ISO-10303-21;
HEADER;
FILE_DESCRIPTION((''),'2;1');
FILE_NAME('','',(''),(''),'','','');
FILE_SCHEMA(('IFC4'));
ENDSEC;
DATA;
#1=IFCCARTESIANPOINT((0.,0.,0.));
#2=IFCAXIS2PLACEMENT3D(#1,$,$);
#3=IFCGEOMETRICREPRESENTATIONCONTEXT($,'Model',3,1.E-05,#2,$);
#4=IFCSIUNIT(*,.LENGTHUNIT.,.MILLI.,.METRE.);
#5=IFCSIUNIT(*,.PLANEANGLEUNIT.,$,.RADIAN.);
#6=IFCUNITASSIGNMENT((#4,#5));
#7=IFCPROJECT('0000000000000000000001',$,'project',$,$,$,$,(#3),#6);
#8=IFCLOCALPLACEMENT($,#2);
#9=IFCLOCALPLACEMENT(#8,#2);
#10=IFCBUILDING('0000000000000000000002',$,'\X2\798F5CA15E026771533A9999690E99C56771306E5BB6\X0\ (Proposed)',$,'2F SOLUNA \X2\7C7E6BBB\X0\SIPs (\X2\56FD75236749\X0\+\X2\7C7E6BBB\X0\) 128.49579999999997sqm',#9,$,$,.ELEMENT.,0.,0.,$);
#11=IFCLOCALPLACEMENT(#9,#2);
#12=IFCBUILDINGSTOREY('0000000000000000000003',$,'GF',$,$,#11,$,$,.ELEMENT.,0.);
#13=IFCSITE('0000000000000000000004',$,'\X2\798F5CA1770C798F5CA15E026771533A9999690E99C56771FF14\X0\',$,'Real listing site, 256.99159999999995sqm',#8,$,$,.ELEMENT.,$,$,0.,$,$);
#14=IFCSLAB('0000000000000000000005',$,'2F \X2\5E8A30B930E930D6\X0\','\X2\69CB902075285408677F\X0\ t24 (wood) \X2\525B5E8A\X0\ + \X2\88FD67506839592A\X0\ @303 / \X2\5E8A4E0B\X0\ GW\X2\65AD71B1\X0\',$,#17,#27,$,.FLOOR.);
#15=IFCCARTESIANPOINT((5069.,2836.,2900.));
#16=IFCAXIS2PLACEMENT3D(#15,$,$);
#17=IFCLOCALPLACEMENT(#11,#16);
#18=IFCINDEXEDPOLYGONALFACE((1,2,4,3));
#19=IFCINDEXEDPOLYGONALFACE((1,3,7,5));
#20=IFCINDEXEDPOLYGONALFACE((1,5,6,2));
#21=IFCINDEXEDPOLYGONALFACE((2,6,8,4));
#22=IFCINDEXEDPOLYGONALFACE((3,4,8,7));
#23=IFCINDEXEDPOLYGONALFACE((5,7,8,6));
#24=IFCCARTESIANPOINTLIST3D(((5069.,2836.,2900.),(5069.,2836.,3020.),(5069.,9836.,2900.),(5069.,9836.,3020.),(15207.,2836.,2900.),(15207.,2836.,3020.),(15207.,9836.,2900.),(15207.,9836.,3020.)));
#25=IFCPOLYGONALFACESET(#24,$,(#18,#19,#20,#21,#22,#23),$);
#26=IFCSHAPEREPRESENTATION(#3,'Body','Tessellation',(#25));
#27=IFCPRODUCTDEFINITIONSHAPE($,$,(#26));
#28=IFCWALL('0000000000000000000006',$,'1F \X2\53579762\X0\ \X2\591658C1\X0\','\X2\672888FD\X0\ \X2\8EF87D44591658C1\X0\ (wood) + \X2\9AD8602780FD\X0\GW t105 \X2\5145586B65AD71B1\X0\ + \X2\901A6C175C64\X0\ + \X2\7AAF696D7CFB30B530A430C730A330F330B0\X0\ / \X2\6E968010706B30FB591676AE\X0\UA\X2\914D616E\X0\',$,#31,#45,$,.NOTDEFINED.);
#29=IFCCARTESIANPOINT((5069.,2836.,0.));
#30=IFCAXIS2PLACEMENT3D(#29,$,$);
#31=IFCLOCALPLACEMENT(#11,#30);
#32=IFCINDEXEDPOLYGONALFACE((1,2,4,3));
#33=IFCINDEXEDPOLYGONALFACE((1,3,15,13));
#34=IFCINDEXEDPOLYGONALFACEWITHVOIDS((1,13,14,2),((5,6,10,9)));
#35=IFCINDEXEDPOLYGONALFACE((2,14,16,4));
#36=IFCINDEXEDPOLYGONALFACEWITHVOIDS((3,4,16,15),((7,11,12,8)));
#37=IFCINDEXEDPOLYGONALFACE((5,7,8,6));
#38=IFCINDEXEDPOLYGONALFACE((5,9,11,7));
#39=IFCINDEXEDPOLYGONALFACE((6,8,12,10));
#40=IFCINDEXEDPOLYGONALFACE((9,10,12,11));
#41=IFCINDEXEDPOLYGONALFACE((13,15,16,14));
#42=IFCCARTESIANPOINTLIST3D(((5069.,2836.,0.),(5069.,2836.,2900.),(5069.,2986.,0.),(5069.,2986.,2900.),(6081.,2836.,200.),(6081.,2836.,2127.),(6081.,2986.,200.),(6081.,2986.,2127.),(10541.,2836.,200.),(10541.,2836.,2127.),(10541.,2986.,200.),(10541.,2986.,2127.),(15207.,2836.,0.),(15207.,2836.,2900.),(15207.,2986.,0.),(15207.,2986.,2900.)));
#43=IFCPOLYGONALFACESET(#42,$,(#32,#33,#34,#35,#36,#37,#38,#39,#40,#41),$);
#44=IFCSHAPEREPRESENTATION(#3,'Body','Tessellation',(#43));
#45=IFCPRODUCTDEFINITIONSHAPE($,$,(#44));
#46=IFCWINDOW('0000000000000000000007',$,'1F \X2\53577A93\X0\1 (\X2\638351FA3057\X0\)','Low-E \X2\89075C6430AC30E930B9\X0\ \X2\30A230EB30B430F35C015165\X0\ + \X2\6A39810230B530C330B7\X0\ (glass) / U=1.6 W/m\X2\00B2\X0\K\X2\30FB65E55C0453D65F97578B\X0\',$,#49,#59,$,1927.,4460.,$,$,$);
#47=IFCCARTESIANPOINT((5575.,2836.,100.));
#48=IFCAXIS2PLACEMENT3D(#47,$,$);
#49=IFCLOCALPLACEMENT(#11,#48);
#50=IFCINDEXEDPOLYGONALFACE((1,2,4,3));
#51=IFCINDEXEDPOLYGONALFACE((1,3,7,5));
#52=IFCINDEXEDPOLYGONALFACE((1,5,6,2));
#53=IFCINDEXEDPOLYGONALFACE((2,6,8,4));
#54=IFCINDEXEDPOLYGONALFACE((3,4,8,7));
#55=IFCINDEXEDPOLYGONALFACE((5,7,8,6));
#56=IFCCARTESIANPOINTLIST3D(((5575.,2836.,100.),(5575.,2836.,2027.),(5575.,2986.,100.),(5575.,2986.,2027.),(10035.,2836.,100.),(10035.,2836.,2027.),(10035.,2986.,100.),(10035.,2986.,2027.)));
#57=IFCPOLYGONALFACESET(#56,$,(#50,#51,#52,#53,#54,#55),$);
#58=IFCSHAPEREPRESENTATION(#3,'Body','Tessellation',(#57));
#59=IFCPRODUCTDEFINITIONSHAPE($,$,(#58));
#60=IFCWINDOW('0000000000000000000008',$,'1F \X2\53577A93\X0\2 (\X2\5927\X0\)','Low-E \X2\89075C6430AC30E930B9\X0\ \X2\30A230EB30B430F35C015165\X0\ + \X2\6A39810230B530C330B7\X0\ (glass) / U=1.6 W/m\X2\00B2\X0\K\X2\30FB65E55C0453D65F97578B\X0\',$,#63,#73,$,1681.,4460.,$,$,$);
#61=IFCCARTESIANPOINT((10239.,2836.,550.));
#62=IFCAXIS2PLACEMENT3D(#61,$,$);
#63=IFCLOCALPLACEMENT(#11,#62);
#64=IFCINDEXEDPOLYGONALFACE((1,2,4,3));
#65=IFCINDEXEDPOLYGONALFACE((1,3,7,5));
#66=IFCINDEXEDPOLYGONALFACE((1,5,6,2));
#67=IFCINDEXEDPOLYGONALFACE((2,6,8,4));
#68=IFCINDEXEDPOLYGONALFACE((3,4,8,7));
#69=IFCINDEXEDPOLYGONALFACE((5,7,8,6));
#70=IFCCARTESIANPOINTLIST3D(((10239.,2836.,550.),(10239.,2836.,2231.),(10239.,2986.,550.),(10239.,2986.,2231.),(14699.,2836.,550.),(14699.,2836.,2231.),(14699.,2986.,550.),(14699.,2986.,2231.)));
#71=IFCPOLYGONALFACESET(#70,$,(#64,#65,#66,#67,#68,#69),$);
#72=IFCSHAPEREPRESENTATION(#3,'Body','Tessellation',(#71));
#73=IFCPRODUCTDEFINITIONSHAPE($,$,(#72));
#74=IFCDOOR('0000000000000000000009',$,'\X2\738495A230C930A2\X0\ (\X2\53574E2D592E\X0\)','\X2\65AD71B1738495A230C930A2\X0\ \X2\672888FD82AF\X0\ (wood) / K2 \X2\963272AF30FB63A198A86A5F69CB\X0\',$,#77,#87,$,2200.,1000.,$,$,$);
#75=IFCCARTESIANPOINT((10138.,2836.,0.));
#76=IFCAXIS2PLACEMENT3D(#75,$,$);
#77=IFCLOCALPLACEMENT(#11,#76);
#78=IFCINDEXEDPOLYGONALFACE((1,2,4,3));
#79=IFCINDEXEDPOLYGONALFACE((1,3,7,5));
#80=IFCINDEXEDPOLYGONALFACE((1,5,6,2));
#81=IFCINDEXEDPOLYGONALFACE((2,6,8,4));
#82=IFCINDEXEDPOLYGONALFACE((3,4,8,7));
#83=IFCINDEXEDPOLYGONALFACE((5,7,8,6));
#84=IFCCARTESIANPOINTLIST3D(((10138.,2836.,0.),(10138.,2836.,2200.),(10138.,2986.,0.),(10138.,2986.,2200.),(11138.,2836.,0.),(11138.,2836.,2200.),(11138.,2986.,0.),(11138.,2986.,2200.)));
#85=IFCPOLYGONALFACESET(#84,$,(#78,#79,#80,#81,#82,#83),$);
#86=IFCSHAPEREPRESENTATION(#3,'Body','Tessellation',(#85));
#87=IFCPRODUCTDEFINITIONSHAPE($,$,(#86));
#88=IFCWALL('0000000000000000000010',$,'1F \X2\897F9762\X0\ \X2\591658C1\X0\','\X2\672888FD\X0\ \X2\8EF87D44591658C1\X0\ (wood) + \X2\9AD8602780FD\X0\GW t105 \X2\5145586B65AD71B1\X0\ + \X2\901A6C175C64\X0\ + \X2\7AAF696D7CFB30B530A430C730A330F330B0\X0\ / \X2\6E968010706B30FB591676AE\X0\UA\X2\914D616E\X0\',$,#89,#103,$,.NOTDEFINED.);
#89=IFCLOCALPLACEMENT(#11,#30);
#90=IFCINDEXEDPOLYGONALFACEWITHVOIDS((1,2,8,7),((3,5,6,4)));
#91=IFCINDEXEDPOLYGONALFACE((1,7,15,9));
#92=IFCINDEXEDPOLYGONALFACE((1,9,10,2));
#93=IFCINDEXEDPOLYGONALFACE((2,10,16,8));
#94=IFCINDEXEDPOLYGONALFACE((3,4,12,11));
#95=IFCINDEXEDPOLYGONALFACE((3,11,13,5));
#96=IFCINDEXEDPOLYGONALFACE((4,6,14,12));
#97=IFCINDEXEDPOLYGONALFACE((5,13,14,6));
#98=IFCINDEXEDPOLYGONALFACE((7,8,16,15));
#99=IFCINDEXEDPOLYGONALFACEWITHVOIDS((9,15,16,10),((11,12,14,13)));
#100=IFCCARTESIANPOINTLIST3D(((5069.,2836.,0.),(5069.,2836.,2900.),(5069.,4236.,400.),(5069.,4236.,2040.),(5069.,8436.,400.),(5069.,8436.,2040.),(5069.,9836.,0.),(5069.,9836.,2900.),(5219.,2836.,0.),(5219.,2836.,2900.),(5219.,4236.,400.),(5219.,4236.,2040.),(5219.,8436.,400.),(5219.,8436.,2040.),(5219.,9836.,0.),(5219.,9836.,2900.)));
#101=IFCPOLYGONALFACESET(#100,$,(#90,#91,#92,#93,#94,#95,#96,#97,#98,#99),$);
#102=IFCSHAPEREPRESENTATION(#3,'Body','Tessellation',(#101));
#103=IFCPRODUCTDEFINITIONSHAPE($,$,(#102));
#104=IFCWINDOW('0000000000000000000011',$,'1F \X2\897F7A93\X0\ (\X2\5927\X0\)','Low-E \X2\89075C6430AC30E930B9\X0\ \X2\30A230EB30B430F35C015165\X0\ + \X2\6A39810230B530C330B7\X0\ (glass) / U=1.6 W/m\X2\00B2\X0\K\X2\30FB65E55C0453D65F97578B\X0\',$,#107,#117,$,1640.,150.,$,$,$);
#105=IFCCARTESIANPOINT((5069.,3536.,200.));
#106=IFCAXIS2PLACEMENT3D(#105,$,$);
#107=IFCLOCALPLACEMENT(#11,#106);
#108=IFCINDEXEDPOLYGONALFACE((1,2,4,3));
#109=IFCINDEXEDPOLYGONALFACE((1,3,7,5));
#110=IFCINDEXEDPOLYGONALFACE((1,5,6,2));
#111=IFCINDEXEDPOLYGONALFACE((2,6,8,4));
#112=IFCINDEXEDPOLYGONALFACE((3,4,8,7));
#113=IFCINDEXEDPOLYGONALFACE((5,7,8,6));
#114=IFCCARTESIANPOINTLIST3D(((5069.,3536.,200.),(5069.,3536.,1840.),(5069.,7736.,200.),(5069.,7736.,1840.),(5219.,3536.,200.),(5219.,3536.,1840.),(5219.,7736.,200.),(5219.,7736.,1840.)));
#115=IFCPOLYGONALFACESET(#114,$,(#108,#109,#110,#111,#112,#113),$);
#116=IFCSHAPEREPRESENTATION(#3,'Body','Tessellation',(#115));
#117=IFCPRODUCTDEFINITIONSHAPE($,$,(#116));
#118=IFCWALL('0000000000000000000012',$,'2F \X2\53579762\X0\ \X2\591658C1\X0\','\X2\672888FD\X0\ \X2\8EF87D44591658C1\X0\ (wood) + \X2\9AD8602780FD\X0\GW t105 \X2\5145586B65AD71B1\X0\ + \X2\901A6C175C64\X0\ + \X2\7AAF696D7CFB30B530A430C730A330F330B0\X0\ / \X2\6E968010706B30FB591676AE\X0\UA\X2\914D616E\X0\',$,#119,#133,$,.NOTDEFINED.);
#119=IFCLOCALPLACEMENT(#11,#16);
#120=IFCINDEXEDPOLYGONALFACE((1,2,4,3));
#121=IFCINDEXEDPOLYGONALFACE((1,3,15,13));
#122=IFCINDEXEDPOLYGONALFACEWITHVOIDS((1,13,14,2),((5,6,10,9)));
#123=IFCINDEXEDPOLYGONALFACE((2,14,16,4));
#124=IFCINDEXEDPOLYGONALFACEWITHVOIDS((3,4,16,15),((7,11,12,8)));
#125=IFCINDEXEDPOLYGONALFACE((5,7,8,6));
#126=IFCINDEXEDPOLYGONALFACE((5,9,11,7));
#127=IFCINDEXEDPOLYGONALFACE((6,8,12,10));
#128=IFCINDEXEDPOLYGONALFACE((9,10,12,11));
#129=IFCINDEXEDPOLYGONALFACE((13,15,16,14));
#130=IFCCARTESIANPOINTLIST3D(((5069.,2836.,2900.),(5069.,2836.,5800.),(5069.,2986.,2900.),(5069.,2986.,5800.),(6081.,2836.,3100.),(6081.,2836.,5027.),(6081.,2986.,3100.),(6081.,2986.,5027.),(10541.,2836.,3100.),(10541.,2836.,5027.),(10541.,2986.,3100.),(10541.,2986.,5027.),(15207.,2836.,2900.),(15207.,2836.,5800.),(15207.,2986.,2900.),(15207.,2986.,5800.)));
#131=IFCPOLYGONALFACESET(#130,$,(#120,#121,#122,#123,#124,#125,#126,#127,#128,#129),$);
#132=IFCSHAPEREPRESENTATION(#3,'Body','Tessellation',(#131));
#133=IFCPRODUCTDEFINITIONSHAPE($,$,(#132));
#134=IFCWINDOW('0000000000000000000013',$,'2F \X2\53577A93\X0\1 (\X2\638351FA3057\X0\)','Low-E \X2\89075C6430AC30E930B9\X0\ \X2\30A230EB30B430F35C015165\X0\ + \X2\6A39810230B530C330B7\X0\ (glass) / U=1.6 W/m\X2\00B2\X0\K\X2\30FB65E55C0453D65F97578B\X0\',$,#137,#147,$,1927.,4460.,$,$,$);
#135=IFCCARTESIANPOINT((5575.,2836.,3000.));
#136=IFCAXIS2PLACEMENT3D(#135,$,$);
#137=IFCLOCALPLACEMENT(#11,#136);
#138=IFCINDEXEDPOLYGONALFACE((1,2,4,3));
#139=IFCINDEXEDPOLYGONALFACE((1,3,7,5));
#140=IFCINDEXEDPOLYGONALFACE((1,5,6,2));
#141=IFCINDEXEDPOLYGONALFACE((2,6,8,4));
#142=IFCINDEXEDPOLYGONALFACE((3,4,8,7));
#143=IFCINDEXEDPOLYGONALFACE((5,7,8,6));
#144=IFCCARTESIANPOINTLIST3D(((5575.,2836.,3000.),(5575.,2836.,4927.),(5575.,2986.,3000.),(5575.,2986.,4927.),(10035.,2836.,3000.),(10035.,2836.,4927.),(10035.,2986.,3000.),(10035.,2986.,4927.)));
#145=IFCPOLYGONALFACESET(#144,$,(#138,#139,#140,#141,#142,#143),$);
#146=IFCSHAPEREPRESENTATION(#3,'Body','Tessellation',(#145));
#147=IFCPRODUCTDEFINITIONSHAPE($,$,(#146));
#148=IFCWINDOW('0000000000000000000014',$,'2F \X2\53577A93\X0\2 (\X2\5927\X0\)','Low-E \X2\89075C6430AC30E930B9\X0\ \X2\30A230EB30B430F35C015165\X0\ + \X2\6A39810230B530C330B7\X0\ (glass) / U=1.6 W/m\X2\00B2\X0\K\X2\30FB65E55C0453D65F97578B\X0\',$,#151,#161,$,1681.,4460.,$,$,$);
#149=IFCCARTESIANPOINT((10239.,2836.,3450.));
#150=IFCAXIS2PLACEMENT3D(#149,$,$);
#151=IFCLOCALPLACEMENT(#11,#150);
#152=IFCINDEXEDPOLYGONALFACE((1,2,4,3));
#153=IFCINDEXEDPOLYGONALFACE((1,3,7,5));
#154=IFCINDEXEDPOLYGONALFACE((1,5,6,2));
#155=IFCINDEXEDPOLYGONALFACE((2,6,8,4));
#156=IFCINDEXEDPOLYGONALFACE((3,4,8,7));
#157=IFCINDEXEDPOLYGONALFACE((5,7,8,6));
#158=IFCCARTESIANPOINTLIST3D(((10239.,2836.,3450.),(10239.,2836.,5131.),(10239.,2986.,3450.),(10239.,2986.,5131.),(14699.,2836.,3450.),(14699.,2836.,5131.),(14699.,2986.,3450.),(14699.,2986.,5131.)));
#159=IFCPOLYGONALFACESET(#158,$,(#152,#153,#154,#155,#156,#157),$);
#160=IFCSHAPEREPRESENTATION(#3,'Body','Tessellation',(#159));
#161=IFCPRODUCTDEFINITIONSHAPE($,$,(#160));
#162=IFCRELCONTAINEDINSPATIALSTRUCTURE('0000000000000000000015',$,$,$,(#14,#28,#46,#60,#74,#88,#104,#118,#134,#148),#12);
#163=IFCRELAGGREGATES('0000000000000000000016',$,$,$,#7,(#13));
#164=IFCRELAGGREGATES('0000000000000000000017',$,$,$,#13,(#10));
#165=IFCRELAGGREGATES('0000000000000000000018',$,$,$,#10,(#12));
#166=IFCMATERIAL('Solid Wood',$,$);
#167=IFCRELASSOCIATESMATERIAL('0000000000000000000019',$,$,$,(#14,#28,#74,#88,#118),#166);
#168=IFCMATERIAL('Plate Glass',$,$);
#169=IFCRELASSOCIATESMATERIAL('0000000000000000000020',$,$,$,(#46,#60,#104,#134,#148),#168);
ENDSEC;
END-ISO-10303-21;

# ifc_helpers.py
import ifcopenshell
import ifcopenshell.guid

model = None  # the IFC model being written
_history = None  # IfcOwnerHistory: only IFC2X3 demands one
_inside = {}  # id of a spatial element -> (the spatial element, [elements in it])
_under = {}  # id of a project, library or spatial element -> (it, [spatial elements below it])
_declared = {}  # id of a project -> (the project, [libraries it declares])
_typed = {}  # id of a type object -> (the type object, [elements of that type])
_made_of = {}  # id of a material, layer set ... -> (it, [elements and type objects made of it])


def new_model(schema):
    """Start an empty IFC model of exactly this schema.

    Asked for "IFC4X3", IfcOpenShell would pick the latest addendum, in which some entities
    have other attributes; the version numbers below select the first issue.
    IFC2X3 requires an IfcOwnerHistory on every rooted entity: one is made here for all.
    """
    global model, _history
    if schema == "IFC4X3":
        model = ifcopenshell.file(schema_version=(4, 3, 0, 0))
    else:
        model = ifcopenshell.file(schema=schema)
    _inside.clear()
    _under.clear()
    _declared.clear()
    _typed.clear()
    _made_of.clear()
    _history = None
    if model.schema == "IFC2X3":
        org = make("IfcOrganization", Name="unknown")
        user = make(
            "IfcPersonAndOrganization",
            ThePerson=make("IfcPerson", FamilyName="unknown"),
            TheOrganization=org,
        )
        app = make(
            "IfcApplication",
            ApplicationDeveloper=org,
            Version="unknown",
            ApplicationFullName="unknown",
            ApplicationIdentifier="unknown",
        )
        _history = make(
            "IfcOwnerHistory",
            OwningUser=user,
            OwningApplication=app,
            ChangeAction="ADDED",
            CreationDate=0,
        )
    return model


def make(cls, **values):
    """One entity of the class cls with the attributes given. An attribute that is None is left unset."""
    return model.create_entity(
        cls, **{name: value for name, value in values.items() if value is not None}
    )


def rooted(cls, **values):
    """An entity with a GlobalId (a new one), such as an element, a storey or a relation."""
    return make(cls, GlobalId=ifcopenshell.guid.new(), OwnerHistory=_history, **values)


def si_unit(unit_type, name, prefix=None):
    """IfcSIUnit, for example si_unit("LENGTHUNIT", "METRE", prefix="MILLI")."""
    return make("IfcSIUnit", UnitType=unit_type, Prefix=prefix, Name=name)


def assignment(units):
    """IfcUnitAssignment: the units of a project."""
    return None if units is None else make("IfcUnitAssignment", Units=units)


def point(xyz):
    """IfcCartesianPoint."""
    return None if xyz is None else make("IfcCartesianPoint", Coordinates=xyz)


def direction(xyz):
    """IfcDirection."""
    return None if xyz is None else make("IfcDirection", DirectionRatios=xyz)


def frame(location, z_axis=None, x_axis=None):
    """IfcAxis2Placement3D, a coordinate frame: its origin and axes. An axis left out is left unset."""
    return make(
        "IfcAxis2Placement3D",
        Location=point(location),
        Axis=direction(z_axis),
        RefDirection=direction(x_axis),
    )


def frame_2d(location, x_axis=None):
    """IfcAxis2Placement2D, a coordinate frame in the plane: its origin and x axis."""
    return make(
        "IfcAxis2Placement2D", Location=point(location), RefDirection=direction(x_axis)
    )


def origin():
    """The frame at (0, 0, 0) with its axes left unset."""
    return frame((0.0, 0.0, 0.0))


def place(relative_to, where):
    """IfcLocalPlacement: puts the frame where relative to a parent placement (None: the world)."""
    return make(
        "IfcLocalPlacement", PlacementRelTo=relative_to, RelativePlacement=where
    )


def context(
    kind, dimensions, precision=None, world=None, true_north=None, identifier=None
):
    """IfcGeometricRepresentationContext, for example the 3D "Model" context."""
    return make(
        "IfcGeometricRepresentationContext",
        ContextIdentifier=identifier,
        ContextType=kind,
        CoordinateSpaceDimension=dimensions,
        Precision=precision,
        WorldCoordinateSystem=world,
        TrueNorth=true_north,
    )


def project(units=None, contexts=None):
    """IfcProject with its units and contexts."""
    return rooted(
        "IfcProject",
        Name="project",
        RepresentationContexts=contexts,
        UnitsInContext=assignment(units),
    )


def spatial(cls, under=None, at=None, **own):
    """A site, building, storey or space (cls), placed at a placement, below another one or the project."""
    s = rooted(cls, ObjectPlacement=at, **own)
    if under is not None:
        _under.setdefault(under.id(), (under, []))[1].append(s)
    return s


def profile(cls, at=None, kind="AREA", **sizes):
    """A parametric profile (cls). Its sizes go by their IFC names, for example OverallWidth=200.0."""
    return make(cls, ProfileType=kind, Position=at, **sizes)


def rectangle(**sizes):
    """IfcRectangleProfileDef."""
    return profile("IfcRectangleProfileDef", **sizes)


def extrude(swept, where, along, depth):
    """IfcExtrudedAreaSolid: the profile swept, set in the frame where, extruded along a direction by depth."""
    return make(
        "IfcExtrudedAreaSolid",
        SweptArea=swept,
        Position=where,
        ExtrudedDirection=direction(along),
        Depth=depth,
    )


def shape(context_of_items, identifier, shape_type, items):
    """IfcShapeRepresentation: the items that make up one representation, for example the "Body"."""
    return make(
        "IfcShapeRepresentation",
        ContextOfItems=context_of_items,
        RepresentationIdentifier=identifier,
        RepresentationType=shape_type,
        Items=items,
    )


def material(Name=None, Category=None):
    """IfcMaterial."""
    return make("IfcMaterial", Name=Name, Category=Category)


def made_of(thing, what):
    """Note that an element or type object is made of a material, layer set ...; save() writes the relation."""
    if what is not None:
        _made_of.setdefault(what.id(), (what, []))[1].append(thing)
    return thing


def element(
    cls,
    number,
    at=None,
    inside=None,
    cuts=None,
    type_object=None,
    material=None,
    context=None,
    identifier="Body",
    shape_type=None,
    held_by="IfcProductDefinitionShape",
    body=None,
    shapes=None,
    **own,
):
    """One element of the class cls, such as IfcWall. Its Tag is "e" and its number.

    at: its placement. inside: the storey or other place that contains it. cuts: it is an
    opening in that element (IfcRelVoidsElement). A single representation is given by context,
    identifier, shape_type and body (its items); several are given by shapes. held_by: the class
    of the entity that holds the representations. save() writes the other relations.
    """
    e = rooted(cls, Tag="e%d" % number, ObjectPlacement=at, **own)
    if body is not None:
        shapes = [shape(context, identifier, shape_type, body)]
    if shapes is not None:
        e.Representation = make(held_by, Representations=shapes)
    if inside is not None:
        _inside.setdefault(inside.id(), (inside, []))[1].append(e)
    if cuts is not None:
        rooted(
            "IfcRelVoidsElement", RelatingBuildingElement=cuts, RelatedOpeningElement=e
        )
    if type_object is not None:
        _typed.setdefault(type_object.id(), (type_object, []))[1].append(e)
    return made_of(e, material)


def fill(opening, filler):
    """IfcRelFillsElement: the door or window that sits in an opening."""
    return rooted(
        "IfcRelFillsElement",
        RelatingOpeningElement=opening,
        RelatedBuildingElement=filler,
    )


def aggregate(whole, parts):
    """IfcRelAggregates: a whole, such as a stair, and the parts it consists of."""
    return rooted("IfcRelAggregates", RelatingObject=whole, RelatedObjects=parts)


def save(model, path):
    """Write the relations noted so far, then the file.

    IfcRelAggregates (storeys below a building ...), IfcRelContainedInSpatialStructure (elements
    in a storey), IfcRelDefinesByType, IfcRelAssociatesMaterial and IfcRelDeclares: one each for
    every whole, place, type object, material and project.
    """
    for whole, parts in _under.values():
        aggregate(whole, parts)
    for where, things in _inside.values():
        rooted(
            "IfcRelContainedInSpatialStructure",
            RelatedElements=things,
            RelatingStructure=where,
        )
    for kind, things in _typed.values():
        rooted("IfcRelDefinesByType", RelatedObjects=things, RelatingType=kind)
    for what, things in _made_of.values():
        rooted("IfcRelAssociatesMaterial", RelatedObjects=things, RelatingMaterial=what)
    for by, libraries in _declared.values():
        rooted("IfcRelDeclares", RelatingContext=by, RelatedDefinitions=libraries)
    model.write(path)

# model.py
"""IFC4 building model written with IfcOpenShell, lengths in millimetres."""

from ifc_helpers import new_model, si_unit, frame, frame_2d, origin, place, context, project, spatial, rectangle, extrude, material, element, fill, save


model = new_model("IFC4")

# Units and contexts
model_context = context("Model", 3, precision=1e-05, world=origin())
ifc_project = project(units=[si_unit("LENGTHUNIT", "METRE", prefix="MILLI"), si_unit("PLANEANGLEUNIT", "RADIAN")], contexts=[model_context])

# Site, building, storey
site_placement = place(None, origin())
site = spatial("IfcSite", under=ifc_project, at=site_placement, Name="福岡県福岡市東区香椎駅東４", ObjectType="Real listing site, 256.99159999999995sqm", CompositionType="ELEMENT", RefElevation=0.0)
building_placement = place(site_placement, origin())
building = spatial("IfcBuilding", under=site, at=building_placement, Name="福岡市東区香椎駅東の家 (Proposed)", ObjectType="2F SOLUNA 籾殻SIPs (国産杉+籾殻) 128.49579999999997sqm", CompositionType="ELEMENT", ElevationOfRefHeight=0.0, ElevationOfTerrain=0.0)
storey_placement = place(building_placement, origin())
storey = spatial("IfcBuildingStorey", under=building, at=storey_placement, Name="GF", CompositionType="ELEMENT", Elevation=0.0)

# Slab
ifc_material_1 = material(Name="Solid Wood")
slab_1_placement = place(storey_placement, frame((5069.0, 2836.0, 2900.0)))
element("IfcSlab", 1, at=slab_1_placement, inside=storey, material=ifc_material_1, Name="2F 床スラブ", Description="構造用合板 t24 (wood) 剛床 + 製材根太 @303 / 床下 GW断熱", PredefinedType="FLOOR", context=model_context, shape_type="SweptSolid", body=[
    extrude(rectangle(XDim=10138.0, YDim=7000.0, at=frame_2d((5069.0, 3500.0))), frame((5069.0, 2836.0, 2900.0)), (0.0, 0.0, 1.0), 120.0),
])

# Wall, openings, windows, door
wall_1_placement = place(storey_placement, frame((5069.0, 2836.0, 0.0)))
wall_1 = element("IfcWall", 2, at=wall_1_placement, inside=storey, material=ifc_material_1, Name="1F 南面 外壁", Description="木製 軸組外壁 (wood) + 高性能GW t105 充填断熱 + 通気層 + 窯業系サイディング / 準耐火・外皮UA配慮", PredefinedType="NOTDEFINED", context=model_context, shape_type="SweptSolid", body=[
    extrude(rectangle(XDim=10138.0, YDim=150.0, at=frame_2d((5069.0, 75.0))), frame((5069.0, 2836.0, 0.0)), (0.0, 0.0, 1.0), 2900.0),
])
opening_1_placement = place(storey_placement, frame((5575.0, 2836.0, 100.0)))
opening_1 = element("IfcOpeningElement", 3, at=opening_1_placement, cuts=wall_1, PredefinedType="NOTDEFINED", context=model_context, shape_type="SweptSolid", body=[
    extrude(rectangle(XDim=4460.0, YDim=150.0, at=frame_2d((2230.0, 75.0))), frame((5575.0, 2836.0, 100.0)), (0.0, 0.0, 1.0), 1927.0),
])
opening_2_placement = place(storey_placement, frame((10239.0, 2836.0, 550.0)))
opening_2 = element("IfcOpeningElement", 4, at=opening_2_placement, cuts=wall_1, PredefinedType="NOTDEFINED", context=model_context, shape_type="SweptSolid", body=[
    extrude(rectangle(XDim=4460.0, YDim=150.0, at=frame_2d((2230.0, 75.0))), frame((10239.0, 2836.0, 550.0)), (0.0, 0.0, 1.0), 1681.0),
])
opening_3_placement = place(storey_placement, frame((10138.0, 2836.0, 0.0)))
opening_3 = element("IfcOpeningElement", 5, at=opening_3_placement, cuts=wall_1, PredefinedType="NOTDEFINED", context=model_context, shape_type="SweptSolid", body=[
    extrude(rectangle(XDim=1000.0, YDim=150.0, at=frame_2d((500.0, 75.0))), frame((10138.0, 2836.0, 0.0)), (0.0, 0.0, 1.0), 2200.0),
])
ifc_material_2 = material(Name="Plate Glass")
window_1_placement = place(storey_placement, frame((5575.0, 2836.0, 100.0)))
window_1 = element("IfcWindow", 6, at=window_1_placement, inside=storey, material=ifc_material_2, Name="1F 南窓1 (掃出し)", Description="Low-E 複層ガラス アルゴン封入 + 樹脂サッシ (glass) / U=1.6 W/m²K・日射取得型", OverallHeight=1927.0, OverallWidth=4460.0, context=model_context, shape_type="SweptSolid", body=[
    extrude(rectangle(XDim=4460.0, YDim=150.0, at=frame_2d((2230.0, 75.0))), frame((5575.0, 2836.0, 100.0)), (0.0, 0.0, 1.0), 1927.0),
])
fill(opening_1, window_1)
window_2_placement = place(storey_placement, frame((10239.0, 2836.0, 550.0)))
window_2 = element("IfcWindow", 7, at=window_2_placement, inside=storey, material=ifc_material_2, Name="1F 南窓2 (大)", Description="Low-E 複層ガラス アルゴン封入 + 樹脂サッシ (glass) / U=1.6 W/m²K・日射取得型", OverallHeight=1681.0, OverallWidth=4460.0, context=model_context, shape_type="SweptSolid", body=[
    extrude(rectangle(XDim=4460.0, YDim=150.0, at=frame_2d((2230.0, 75.0))), frame((10239.0, 2836.0, 550.0)), (0.0, 0.0, 1.0), 1681.0),
])
fill(opening_2, window_2)
door_placement = place(storey_placement, frame((10138.0, 2836.0, 0.0)))
door = element("IfcDoor", 8, at=door_placement, inside=storey, material=ifc_material_1, Name="玄関ドア (南中央)", Description="断熱玄関ドア 木製芯 (wood) / K2 防犯・採風機構", OverallHeight=2200.0, OverallWidth=1000.0, context=model_context, shape_type="SweptSolid", body=[
    extrude(rectangle(XDim=1000.0, YDim=150.0, at=frame_2d((500.0, 75.0))), frame((10138.0, 2836.0, 0.0)), (0.0, 0.0, 1.0), 2200.0),
])
fill(opening_3, door)

# Wall, opening, window
wall_2_placement = place(storey_placement, frame((5069.0, 2836.0, 0.0)))
wall_2 = element("IfcWall", 9, at=wall_2_placement, inside=storey, material=ifc_material_1, Name="1F 西面 外壁", Description="木製 軸組外壁 (wood) + 高性能GW t105 充填断熱 + 通気層 + 窯業系サイディング / 準耐火・外皮UA配慮", PredefinedType="NOTDEFINED", context=model_context, shape_type="SweptSolid", body=[
    extrude(rectangle(XDim=150.0, YDim=7000.0, at=frame_2d((75.0, 3500.0))), frame((5069.0, 2836.0, 0.0)), (0.0, 0.0, 1.0), 2900.0),
])
opening_4_placement = place(storey_placement, frame((5069.0, 3536.0, 200.0)))
opening_4 = element("IfcOpeningElement", 10, at=opening_4_placement, cuts=wall_2, PredefinedType="NOTDEFINED", context=model_context, shape_type="SweptSolid", body=[
    extrude(rectangle(XDim=150.0, YDim=4200.0, at=frame_2d((75.0, 2100.0))), frame((5069.0, 3536.0, 200.0)), (0.0, 0.0, 1.0), 1640.0),
])
window_3_placement = place(storey_placement, frame((5069.0, 3536.0, 200.0)))
window_3 = element("IfcWindow", 11, at=window_3_placement, inside=storey, material=ifc_material_2, Name="1F 西窓 (大)", Description="Low-E 複層ガラス アルゴン封入 + 樹脂サッシ (glass) / U=1.6 W/m²K・日射取得型", OverallHeight=1640.0, OverallWidth=150.0, context=model_context, shape_type="SweptSolid", body=[
    extrude(rectangle(XDim=150.0, YDim=4200.0, at=frame_2d((75.0, 2100.0))), frame((5069.0, 3536.0, 200.0)), (0.0, 0.0, 1.0), 1640.0),
])
fill(opening_4, window_3)

# Wall, openings, windows
wall_3_placement = place(storey_placement, frame((5069.0, 2836.0, 2900.0)))
wall_3 = element("IfcWall", 12, at=wall_3_placement, inside=storey, material=ifc_material_1, Name="2F 南面 外壁", Description="木製 軸組外壁 (wood) + 高性能GW t105 充填断熱 + 通気層 + 窯業系サイディング / 準耐火・外皮UA配慮", PredefinedType="NOTDEFINED", context=model_context, shape_type="SweptSolid", body=[
    extrude(rectangle(XDim=10138.0, YDim=150.0, at=frame_2d((5069.0, 75.0))), frame((5069.0, 2836.0, 2900.0)), (0.0, 0.0, 1.0), 2900.0),
])
opening_5_placement = place(storey_placement, frame((5575.0, 2836.0, 3000.0)))
opening_5 = element("IfcOpeningElement", 13, at=opening_5_placement, cuts=wall_3, PredefinedType="NOTDEFINED", context=model_context, shape_type="SweptSolid", body=[
    extrude(rectangle(XDim=4460.0, YDim=150.0, at=frame_2d((2230.0, 75.0))), frame((5575.0, 2836.0, 3000.0)), (0.0, 0.0, 1.0), 1927.0),
])
opening_6_placement = place(storey_placement, frame((10239.0, 2836.0, 3450.0)))
opening_6 = element("IfcOpeningElement", 14, at=opening_6_placement, cuts=wall_3, PredefinedType="NOTDEFINED", context=model_context, shape_type="SweptSolid", body=[
    extrude(rectangle(XDim=4460.0, YDim=150.0, at=frame_2d((2230.0, 75.0))), frame((10239.0, 2836.0, 3450.0)), (0.0, 0.0, 1.0), 1681.0),
])
window_4_placement = place(storey_placement, frame((5575.0, 2836.0, 3000.0)))
window_4 = element("IfcWindow", 15, at=window_4_placement, inside=storey, material=ifc_material_2, Name="2F 南窓1 (掃出し)", Description="Low-E 複層ガラス アルゴン封入 + 樹脂サッシ (glass) / U=1.6 W/m²K・日射取得型", OverallHeight=1927.0, OverallWidth=4460.0, context=model_context, shape_type="SweptSolid", body=[
    extrude(rectangle(XDim=4460.0, YDim=150.0, at=frame_2d((2230.0, 75.0))), frame((5575.0, 2836.0, 3000.0)), (0.0, 0.0, 1.0), 1927.0),
])
fill(opening_5, window_4)
window_5_placement = place(storey_placement, frame((10239.0, 2836.0, 3450.0)))
window_5 = element("IfcWindow", 16, at=window_5_placement, inside=storey, material=ifc_material_2, Name="2F 南窓2 (大)", Description="Low-E 複層ガラス アルゴン封入 + 樹脂サッシ (glass) / U=1.6 W/m²K・日射取得型", OverallHeight=1681.0, OverallWidth=4460.0, context=model_context, shape_type="SweptSolid", body=[
    extrude(rectangle(XDim=4460.0, YDim=150.0, at=frame_2d((2230.0, 75.0))), frame((10239.0, 2836.0, 3450.0)), (0.0, 0.0, 1.0), 1681.0),
])
fill(opening_6, window_5)

save(model, "model.ifc")
